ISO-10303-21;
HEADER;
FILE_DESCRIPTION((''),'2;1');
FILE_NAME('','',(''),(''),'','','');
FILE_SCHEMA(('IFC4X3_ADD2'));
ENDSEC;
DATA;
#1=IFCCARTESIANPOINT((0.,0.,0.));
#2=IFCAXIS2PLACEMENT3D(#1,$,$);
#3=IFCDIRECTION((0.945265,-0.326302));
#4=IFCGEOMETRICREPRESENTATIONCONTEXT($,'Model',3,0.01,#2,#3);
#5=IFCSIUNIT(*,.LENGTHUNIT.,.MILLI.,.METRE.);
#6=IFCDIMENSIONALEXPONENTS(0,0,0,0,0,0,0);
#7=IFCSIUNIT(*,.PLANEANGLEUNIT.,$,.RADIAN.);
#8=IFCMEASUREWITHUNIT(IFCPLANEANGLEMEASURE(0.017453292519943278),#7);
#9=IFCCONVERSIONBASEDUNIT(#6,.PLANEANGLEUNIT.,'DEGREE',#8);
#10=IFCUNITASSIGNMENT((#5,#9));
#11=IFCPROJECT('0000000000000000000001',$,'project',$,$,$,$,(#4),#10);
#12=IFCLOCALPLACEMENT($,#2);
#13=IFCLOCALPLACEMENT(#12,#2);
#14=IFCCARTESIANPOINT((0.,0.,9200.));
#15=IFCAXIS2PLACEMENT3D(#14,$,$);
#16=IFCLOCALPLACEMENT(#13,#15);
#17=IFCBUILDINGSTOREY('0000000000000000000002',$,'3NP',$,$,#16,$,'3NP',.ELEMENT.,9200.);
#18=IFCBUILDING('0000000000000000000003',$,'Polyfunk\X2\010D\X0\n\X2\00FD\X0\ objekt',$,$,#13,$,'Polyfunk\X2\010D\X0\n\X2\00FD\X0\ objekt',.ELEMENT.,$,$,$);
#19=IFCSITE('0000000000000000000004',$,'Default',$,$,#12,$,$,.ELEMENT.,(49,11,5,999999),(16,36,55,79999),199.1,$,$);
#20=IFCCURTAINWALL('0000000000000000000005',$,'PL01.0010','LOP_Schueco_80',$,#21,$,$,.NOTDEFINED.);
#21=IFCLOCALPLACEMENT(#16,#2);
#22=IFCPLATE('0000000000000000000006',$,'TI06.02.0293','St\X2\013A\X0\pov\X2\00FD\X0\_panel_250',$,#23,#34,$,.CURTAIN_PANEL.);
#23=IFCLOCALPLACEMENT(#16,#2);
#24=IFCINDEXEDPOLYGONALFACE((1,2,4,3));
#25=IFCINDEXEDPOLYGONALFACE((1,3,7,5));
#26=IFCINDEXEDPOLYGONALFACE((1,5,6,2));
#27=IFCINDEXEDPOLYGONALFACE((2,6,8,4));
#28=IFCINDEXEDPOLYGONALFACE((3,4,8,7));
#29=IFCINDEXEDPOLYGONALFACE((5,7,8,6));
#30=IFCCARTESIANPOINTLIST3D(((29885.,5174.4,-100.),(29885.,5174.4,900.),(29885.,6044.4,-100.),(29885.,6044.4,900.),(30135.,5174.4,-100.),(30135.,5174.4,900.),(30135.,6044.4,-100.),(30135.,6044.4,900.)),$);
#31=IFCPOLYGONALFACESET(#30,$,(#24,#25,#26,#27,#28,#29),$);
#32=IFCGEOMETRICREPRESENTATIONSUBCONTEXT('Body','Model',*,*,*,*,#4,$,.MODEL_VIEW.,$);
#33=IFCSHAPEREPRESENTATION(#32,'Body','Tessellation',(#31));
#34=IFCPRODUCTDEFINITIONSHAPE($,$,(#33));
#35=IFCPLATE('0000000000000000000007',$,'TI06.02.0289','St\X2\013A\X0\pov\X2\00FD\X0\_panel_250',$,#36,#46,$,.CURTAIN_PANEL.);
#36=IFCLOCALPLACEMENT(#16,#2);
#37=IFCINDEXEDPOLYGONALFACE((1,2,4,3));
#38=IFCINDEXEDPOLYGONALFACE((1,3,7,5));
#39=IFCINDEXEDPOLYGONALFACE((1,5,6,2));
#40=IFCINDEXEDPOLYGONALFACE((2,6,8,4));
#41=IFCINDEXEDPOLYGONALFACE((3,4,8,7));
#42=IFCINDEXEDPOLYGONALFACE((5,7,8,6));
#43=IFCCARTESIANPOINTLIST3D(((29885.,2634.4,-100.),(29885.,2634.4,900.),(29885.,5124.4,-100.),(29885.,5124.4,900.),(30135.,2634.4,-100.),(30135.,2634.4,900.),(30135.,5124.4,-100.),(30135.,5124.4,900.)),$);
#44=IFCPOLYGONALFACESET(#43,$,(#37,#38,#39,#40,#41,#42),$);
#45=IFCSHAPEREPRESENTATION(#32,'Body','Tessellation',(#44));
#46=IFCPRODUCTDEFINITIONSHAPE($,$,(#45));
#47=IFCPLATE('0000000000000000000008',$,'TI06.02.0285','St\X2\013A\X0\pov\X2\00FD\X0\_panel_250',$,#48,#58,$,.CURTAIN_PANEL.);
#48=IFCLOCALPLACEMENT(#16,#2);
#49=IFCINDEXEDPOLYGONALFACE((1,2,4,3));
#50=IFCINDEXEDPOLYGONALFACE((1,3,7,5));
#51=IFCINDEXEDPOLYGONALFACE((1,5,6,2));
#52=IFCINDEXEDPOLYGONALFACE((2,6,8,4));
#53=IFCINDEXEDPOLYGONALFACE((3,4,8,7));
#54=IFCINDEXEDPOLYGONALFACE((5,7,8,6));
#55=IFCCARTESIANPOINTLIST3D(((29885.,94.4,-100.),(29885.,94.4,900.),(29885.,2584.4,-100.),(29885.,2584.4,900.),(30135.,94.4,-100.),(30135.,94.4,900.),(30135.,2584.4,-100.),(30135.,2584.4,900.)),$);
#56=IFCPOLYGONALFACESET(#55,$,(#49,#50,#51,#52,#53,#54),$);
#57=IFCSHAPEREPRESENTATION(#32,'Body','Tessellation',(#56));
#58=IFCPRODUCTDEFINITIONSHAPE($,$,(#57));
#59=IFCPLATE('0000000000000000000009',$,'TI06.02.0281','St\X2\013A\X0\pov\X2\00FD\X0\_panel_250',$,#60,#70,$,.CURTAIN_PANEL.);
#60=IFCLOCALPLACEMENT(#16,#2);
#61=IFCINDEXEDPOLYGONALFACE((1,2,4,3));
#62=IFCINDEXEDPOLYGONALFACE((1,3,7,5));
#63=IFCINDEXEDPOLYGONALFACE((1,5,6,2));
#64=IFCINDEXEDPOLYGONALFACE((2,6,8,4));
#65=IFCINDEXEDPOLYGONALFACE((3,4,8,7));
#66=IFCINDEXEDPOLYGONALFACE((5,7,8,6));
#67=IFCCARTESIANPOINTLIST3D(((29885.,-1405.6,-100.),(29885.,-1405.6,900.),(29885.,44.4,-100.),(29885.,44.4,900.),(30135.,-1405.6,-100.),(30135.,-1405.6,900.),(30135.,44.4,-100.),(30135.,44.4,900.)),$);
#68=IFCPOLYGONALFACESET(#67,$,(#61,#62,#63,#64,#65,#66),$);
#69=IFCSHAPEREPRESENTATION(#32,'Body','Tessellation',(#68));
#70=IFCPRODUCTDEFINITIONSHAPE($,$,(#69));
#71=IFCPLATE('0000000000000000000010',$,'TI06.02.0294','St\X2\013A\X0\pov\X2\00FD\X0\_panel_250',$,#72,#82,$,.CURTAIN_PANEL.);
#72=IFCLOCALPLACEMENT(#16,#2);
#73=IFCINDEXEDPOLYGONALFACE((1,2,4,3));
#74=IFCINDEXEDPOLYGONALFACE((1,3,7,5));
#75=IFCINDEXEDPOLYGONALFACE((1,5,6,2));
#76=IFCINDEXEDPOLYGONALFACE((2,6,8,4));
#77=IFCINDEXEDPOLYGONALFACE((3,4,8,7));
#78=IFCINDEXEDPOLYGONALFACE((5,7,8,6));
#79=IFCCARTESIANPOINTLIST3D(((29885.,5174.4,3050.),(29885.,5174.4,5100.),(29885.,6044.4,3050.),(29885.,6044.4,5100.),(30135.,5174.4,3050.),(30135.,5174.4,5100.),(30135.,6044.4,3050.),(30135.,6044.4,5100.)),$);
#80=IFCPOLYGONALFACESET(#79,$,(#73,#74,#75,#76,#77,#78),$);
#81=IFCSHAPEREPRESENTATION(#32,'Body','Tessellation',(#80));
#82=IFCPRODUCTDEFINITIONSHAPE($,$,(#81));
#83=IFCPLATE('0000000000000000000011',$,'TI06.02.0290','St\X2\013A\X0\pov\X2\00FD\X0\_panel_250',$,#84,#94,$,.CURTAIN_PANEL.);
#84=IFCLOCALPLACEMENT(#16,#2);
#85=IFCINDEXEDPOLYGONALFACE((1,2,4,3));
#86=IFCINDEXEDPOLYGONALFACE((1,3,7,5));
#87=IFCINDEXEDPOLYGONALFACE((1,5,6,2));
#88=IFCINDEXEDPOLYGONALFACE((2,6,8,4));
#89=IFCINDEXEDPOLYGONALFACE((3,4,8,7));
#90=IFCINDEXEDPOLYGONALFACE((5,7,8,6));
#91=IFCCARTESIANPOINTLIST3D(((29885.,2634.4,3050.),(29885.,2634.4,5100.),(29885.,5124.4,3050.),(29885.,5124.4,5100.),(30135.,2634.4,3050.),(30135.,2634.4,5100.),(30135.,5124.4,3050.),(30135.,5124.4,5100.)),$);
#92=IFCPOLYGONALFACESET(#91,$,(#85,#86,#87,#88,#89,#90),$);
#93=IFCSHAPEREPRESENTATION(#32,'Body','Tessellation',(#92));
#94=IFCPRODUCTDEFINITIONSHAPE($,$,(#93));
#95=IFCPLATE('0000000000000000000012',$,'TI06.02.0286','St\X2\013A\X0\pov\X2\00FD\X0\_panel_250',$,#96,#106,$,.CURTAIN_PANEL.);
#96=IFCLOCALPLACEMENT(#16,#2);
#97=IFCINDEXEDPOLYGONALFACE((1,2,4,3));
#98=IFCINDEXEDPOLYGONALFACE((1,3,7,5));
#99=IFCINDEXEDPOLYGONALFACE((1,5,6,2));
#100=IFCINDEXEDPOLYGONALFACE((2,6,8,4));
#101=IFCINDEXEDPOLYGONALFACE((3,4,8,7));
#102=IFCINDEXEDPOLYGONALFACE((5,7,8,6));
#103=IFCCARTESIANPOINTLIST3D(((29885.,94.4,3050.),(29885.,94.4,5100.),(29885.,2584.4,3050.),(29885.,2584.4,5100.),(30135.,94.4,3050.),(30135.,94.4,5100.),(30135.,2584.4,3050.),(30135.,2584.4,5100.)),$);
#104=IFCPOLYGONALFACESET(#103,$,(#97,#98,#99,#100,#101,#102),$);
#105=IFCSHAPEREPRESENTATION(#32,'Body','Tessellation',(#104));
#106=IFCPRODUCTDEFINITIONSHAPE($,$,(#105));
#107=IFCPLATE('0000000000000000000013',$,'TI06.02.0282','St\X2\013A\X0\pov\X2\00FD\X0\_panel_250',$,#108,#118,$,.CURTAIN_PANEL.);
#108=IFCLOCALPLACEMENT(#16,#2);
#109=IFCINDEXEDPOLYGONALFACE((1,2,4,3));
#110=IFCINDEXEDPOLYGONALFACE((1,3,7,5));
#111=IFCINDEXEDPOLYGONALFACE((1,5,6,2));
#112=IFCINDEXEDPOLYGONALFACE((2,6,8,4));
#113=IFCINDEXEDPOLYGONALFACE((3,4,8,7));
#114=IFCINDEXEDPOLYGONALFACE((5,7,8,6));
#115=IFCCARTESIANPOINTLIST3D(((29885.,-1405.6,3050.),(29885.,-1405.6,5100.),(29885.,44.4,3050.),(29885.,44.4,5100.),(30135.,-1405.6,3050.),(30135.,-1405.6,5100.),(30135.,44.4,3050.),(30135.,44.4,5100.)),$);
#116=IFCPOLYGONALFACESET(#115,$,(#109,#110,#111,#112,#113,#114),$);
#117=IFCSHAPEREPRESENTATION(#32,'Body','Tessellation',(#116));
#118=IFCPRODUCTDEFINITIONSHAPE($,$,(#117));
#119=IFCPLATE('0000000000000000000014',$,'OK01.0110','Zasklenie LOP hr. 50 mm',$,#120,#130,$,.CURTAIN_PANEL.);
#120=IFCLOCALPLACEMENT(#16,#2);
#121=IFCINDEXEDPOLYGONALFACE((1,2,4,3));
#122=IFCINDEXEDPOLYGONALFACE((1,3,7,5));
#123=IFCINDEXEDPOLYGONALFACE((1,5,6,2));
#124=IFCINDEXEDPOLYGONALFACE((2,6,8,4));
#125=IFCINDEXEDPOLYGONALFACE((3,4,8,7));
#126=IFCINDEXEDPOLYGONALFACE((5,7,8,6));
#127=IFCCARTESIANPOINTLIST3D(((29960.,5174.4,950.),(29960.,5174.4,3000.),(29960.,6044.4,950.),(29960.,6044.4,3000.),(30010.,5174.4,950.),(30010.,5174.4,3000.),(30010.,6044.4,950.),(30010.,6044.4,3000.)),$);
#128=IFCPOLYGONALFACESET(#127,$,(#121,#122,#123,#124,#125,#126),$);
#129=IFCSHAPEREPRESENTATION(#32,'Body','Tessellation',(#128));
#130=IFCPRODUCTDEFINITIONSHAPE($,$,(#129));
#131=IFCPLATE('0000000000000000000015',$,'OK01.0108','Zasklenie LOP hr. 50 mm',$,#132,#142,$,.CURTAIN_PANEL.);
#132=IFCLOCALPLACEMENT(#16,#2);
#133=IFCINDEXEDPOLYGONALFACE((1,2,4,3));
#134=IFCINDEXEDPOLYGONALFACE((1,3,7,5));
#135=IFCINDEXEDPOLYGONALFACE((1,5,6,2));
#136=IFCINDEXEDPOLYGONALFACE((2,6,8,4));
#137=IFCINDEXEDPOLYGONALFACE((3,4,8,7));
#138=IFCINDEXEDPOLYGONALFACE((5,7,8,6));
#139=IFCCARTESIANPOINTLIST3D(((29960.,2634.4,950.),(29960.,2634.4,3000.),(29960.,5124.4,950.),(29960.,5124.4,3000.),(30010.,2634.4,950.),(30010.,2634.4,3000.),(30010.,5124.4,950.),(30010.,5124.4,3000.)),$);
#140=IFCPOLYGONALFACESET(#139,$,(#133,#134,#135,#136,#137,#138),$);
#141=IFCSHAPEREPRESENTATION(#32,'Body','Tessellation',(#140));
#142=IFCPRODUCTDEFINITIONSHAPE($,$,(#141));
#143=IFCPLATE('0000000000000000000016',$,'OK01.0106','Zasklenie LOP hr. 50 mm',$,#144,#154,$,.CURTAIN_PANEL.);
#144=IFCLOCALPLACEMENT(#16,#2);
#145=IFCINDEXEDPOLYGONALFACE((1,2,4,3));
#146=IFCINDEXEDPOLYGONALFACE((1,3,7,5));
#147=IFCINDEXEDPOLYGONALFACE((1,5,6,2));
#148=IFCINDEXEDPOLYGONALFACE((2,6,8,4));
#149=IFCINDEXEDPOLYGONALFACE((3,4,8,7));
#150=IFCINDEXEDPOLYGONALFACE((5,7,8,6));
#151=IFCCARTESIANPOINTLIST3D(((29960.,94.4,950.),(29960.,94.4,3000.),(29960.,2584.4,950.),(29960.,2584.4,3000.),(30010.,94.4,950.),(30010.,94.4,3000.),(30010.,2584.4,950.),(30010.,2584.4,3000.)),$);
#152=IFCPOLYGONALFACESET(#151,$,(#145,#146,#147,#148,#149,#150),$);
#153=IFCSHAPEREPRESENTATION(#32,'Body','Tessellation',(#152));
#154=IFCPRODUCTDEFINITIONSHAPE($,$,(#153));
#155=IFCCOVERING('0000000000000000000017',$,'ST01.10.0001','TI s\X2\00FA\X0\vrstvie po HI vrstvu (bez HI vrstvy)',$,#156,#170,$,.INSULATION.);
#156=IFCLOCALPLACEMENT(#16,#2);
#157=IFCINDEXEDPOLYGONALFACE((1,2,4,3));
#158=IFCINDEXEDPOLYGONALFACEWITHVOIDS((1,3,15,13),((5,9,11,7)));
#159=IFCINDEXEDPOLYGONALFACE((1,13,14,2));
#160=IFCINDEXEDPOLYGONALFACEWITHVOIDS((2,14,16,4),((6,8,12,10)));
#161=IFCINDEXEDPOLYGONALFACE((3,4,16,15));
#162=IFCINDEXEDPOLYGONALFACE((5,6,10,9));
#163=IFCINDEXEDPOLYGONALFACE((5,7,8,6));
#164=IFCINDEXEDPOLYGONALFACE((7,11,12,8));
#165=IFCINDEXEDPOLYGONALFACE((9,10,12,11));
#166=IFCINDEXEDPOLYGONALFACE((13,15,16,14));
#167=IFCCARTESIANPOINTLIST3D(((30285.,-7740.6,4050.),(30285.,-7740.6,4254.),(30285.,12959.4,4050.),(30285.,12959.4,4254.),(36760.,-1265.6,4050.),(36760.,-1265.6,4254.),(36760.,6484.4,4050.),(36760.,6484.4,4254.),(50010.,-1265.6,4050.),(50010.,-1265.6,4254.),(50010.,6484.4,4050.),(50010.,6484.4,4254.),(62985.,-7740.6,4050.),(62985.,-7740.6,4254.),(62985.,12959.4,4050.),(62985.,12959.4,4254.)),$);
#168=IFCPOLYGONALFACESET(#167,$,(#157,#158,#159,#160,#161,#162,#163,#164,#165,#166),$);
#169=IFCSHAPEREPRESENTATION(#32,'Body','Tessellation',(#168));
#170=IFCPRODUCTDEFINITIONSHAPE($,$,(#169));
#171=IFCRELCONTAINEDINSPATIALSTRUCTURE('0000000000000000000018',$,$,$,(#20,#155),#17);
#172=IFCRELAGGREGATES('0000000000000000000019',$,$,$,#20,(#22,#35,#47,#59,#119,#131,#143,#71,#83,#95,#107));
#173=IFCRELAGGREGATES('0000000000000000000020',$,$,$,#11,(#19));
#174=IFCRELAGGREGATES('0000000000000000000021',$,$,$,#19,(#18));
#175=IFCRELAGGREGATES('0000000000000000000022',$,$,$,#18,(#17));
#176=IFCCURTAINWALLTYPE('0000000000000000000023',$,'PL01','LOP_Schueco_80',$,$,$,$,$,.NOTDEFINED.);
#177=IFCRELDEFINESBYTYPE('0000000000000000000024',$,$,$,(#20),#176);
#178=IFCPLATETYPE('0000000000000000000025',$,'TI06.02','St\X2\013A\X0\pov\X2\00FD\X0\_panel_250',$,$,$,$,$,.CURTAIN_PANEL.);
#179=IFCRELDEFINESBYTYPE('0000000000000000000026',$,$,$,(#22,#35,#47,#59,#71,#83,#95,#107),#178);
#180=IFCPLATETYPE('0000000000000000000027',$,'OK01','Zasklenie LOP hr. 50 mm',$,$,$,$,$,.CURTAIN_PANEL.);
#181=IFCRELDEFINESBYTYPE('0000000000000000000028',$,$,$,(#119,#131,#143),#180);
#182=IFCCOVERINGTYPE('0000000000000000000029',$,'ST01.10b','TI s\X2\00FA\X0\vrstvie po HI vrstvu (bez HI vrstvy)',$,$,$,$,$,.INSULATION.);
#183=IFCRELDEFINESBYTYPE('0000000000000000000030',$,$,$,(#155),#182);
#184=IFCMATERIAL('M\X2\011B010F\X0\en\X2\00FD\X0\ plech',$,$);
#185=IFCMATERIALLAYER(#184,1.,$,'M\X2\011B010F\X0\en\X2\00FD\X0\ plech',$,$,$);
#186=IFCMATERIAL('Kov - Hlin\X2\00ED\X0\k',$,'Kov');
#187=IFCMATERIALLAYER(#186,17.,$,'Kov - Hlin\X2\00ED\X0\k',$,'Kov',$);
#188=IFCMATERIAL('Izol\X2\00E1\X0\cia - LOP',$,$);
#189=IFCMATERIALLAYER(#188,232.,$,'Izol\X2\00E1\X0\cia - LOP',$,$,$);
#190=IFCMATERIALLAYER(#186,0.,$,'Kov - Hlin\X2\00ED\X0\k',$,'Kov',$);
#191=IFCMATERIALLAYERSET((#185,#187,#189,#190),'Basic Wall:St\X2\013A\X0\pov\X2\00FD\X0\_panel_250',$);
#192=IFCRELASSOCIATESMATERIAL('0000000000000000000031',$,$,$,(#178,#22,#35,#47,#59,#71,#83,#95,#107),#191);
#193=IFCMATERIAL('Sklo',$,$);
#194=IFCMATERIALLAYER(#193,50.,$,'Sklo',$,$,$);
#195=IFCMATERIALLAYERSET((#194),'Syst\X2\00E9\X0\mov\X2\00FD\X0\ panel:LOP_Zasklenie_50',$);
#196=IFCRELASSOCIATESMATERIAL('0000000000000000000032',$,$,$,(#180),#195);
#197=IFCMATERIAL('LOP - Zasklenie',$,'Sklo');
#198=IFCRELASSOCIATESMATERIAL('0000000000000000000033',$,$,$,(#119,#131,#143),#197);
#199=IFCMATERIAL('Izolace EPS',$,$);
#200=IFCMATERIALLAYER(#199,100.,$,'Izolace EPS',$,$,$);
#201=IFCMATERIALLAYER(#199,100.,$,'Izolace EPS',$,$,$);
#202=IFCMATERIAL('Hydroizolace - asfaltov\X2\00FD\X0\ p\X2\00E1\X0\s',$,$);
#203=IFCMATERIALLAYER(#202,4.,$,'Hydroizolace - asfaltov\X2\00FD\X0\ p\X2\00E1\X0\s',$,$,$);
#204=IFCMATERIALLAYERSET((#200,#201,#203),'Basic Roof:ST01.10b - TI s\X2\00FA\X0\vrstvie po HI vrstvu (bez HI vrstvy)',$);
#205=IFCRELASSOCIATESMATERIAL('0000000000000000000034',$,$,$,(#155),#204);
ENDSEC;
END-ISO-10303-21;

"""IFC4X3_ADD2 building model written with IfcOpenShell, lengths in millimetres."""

from ifc_helpers import new_model, entity, si_unit, converted_unit, direction, frame, frame_2d, origin, origin_2d_with_axis, place, context, subcontext, project, spatial, rectangle, extrude, source, transform, mapped, material, layer, layer_set, layer_usage, type_object, type_shapes, element, aggregate, save


model = new_model("IFC4X3_ADD2")

# Units and contexts
model_context = context("Model", 3, precision=0.01, world=origin(), true_north=direction((0.945265, -0.326302)))
body_context = subcontext(model_context, "Body", "Model", "MODEL_VIEW")
ifc_project = project(units=[si_unit("LENGTHUNIT", "METRE", prefix="MILLI"), converted_unit("PLANEANGLEUNIT", "DEGREE", entity("IfcPlaneAngleMeasure", 0.017453292519943278), si_unit("PLANEANGLEUNIT", "RADIAN"), dimensions=[0, 0, 0, 0, 0, 0, 0])], contexts=[model_context])

# Site, building, storey
site_placement = place(None, origin())
site = spatial("IfcSite", under=ifc_project, at=site_placement, Name="Default", CompositionType="ELEMENT", RefLatitude=(49, 11, 5, 999999), RefLongitude=(16, 36, 55, 79999), RefElevation=199.1)
building_placement = place(site_placement, origin())
building = spatial("IfcBuilding", under=site, at=building_placement, Name="Polyfunkčný objekt", LongName="Polyfunkčný objekt", CompositionType="ELEMENT")
storey_placement = place(building_placement, frame((0.0, 0.0, 9200.0)))
storey = spatial("IfcBuildingStorey", under=building, at=storey_placement, Name="3NP", LongName="3NP", CompositionType="ELEMENT", Elevation=9200.0)

# Curtain wall
curtain_wall_type = type_object("IfcCurtainWallType", Name="PL01", Description="LOP_Schueco_80", PredefinedType="NOTDEFINED")
curtain_wall_1_placement = place(storey_placement, frame((0.0, 0.0, -9200.0)))
curtain_wall_1 = element("IfcCurtainWall", 1, at=curtain_wall_1_placement, inside=storey, type_object=curtain_wall_type, Name="PL01.0010", Description="LOP_Schueco_80", PredefinedType="NOTDEFINED")

# Plates
ifc_material_1 = material(Name="Měďený plech")
ifc_layer_1 = layer(ifc_material_1, 1.0, Name="Měďený plech")
ifc_material_2 = material(Name="Kov - Hliník", Category="Kov")
ifc_layer_2 = layer(ifc_material_2, 17.0, Name="Kov - Hliník", Category="Kov")
ifc_material_3 = material(Name="Izolácia - LOP")
ifc_layer_3 = layer(ifc_material_3, 232.0, Name="Izolácia - LOP")
ifc_layer_4 = layer(ifc_material_2, 0.0, Name="Kov - Hliník", Category="Kov")
ifc_layer_set_1 = layer_set([ifc_layer_1, ifc_layer_2, ifc_layer_3, ifc_layer_4], Name="Basic Wall:Stĺpový_panel_250")
ifc_layer_usage_1 = layer_usage(ifc_layer_set_1, "AXIS2", "POSITIVE", -125.0)
plate_type_1 = type_object("IfcPlateType", Name="TI06.02", Description="Stĺpový_panel_250", PredefinedType="CURTAIN_PANEL", material=ifc_layer_set_1)
plate_1_placement = place(storey_placement, frame((30010.0, 6044.4, -100.0), z_axis=(0.0, 0.0, 1.0), x_axis=(0.0, -1.0, 0.0)))
plate_1 = element("IfcPlate", 2, at=plate_1_placement, type_object=plate_type_1, material=ifc_layer_usage_1, Name="TI06.02.0293", Description="Stĺpový_panel_250", PredefinedType="CURTAIN_PANEL", context=body_context, shape_type="SweptSolid", body=[
    extrude(rectangle(XDim=250.0, YDim=870.0, at=frame_2d((0.0, 0.0), x_axis=(1.0, 0.0))), frame((435.0, 0.0, 0.0), z_axis=(0.0, 0.0, 1.0), x_axis=(0.0, 1.0, 0.0)), (0.0, 0.0, 1.0), 1000.0),
])
ifc_layer_usage_2 = layer_usage(ifc_layer_set_1, "AXIS2", "POSITIVE", -125.0)
plate_2_placement = place(storey_placement, frame((30010.0, 5124.4, -100.0), z_axis=(0.0, 0.0, 1.0), x_axis=(0.0, -1.0, 0.0)))
plate_2 = element("IfcPlate", 3, at=plate_2_placement, type_object=plate_type_1, material=ifc_layer_usage_2, Name="TI06.02.0289", Description="Stĺpový_panel_250", PredefinedType="CURTAIN_PANEL", context=body_context, shape_type="SweptSolid", body=[
    extrude(rectangle(XDim=250.0, YDim=2490.0, at=frame_2d((0.0, 0.0), x_axis=(1.0, 0.0))), frame((1245.0, 0.0, 0.0), z_axis=(0.0, 0.0, 1.0), x_axis=(0.0, 1.0, 0.0)), (0.0, 0.0, 1.0), 1000.0),
])
ifc_layer_usage_3 = layer_usage(ifc_layer_set_1, "AXIS2", "POSITIVE", -125.0)
plate_3_placement = place(storey_placement, frame((30010.0, 2584.4, -100.0), z_axis=(0.0, 0.0, 1.0), x_axis=(0.0, -1.0, 0.0)))
plate_3 = element("IfcPlate", 4, at=plate_3_placement, type_object=plate_type_1, material=ifc_layer_usage_3, Name="TI06.02.0285", Description="Stĺpový_panel_250", PredefinedType="CURTAIN_PANEL", context=body_context, shape_type="SweptSolid", body=[
    extrude(rectangle(XDim=250.0, YDim=2490.0, at=frame_2d((0.0, 0.0), x_axis=(1.0, 0.0))), frame((1245.0, 0.0, 0.0), z_axis=(0.0, 0.0, 1.0), x_axis=(0.0, 1.0, 0.0)), (0.0, 0.0, 1.0), 1000.0),
])
ifc_layer_usage_4 = layer_usage(ifc_layer_set_1, "AXIS2", "POSITIVE", -125.0)
plate_4_placement = place(storey_placement, frame((30010.0, 44.4, -100.0), z_axis=(0.0, 0.0, 1.0), x_axis=(0.0, -1.0, 0.0)))
plate_4 = element("IfcPlate", 5, at=plate_4_placement, type_object=plate_type_1, material=ifc_layer_usage_4, Name="TI06.02.0281", Description="Stĺpový_panel_250", PredefinedType="CURTAIN_PANEL", context=body_context, shape_type="SweptSolid", body=[
    extrude(rectangle(XDim=250.0, YDim=1450.0, at=frame_2d((0.0, 0.0), x_axis=(1.0, 0.0))), frame((725.0, 0.0, 0.0), z_axis=(0.0, 0.0, 1.0), x_axis=(0.0, 1.0, 0.0)), (0.0, 0.0, 1.0), 1000.0),
])
ifc_layer_usage_5 = layer_usage(ifc_layer_set_1, "AXIS2", "POSITIVE", -125.0)
plate_5_placement = place(storey_placement, frame((30010.0, 6044.4, 3050.0), z_axis=(0.0, 0.0, 1.0), x_axis=(0.0, -1.0, 0.0)))
plate_5 = element("IfcPlate", 6, at=plate_5_placement, type_object=plate_type_1, material=ifc_layer_usage_5, Name="TI06.02.0294", Description="Stĺpový_panel_250", PredefinedType="CURTAIN_PANEL", context=body_context, shape_type="SweptSolid", body=[
    extrude(rectangle(XDim=250.0, YDim=870.0, at=frame_2d((0.0, 0.0), x_axis=(1.0, 0.0))), frame((435.0, 0.0, 0.0), z_axis=(0.0, 0.0, 1.0), x_axis=(0.0, 1.0, 0.0)), (0.0, 0.0, 1.0), 2050.0),
])
ifc_layer_usage_6 = layer_usage(ifc_layer_set_1, "AXIS2", "POSITIVE", -125.0)
plate_6_placement = place(storey_placement, frame((30010.0, 5124.4, 3050.0), z_axis=(0.0, 0.0, 1.0), x_axis=(0.0, -1.0, 0.0)))
plate_6 = element("IfcPlate", 7, at=plate_6_placement, type_object=plate_type_1, material=ifc_layer_usage_6, Name="TI06.02.0290", Description="Stĺpový_panel_250", PredefinedType="CURTAIN_PANEL", context=body_context, shape_type="SweptSolid", body=[
    extrude(rectangle(XDim=250.0, YDim=2490.0, at=frame_2d((0.0, 0.0), x_axis=(1.0, 0.0))), frame((1245.0, 0.0, 0.0), z_axis=(0.0, 0.0, 1.0), x_axis=(0.0, 1.0, 0.0)), (0.0, 0.0, 1.0), 2050.0),
])
ifc_layer_usage_7 = layer_usage(ifc_layer_set_1, "AXIS2", "POSITIVE", -125.0)
plate_7_placement = place(storey_placement, frame((30010.0, 2584.4, 3050.0), z_axis=(0.0, 0.0, 1.0), x_axis=(0.0, -1.0, 0.0)))
plate_7 = element("IfcPlate", 8, at=plate_7_placement, type_object=plate_type_1, material=ifc_layer_usage_7, Name="TI06.02.0286", Description="Stĺpový_panel_250", PredefinedType="CURTAIN_PANEL", context=body_context, shape_type="SweptSolid", body=[
    extrude(rectangle(XDim=250.0, YDim=2490.0, at=frame_2d((0.0, 0.0), x_axis=(1.0, 0.0))), frame((1245.0, 0.0, 0.0), z_axis=(0.0, 0.0, 1.0), x_axis=(0.0, 1.0, 0.0)), (0.0, 0.0, 1.0), 2050.0),
])
ifc_layer_usage_8 = layer_usage(ifc_layer_set_1, "AXIS2", "POSITIVE", -125.0)
plate_8_placement = place(storey_placement, frame((30010.0, 44.4, 3050.0), z_axis=(0.0, 0.0, 1.0), x_axis=(0.0, -1.0, 0.0)))
plate_8 = element("IfcPlate", 9, at=plate_8_placement, type_object=plate_type_1, material=ifc_layer_usage_8, Name="TI06.02.0282", Description="Stĺpový_panel_250", PredefinedType="CURTAIN_PANEL", context=body_context, shape_type="SweptSolid", body=[
    extrude(rectangle(XDim=250.0, YDim=1450.0, at=frame_2d((0.0, 0.0), x_axis=(1.0, 0.0))), frame((725.0, 0.0, 0.0), z_axis=(0.0, 0.0, 1.0), x_axis=(0.0, 1.0, 0.0)), (0.0, 0.0, 1.0), 2050.0),
])
ifc_material_4 = material(Name="LOP - Zasklenie", Category="Sklo")
ifc_material_5 = material(Name="Sklo")
ifc_layer_5 = layer(ifc_material_5, 50.0, Name="Sklo")
ifc_layer_set_2 = layer_set([ifc_layer_5], Name="Systémový panel:LOP_Zasklenie_50")
plate_type_2 = type_object("IfcPlateType", Name="OK01", Description="Zasklenie LOP hr. 50 mm", PredefinedType="CURTAIN_PANEL", material=ifc_layer_set_2)
shared_shape_1 = source(origin(), body_context, "Body", "SweptSolid", [
    extrude(rectangle(XDim=50.0, YDim=870.0, at=origin_2d_with_axis()), frame((0.0, -25.0, 0.0), z_axis=(0.0, 0.0, 1.0), x_axis=(0.0, 1.0, 0.0)), (0.0, 0.0, 1.0), 2050.0),
])
plate_9_placement = place(curtain_wall_1_placement, frame((30010.0, 5609.4, 10150.0), z_axis=(0.0, 0.0, 1.0), x_axis=(0.0, -1.0, 0.0)))
plate_9 = element("IfcPlate", 10, at=plate_9_placement, type_object=plate_type_2, material=ifc_material_4, Name="OK01.0110", Description="Zasklenie LOP hr. 50 mm", PredefinedType="CURTAIN_PANEL", context=body_context, shape_type="MappedRepresentation", body=[
    mapped(shared_shape_1, transform((0.0, 0.0, 0.0), scale=1.0)),
])
shared_shape_2 = source(origin(), body_context, "Body", "SweptSolid", [
    extrude(rectangle(XDim=50.0, YDim=2490.0, at=origin_2d_with_axis()), frame((0.0, -25.0, 0.0), z_axis=(0.0, 0.0, 1.0), x_axis=(0.0, 1.0, 0.0)), (0.0, 0.0, 1.0), 2050.0),
])
type_shapes(plate_type_2, [shared_shape_1, shared_shape_2])
plate_10_placement = place(curtain_wall_1_placement, frame((30010.0, 3879.4, 10150.0), z_axis=(0.0, 0.0, 1.0), x_axis=(0.0, -1.0, 0.0)))
plate_10 = element("IfcPlate", 11, at=plate_10_placement, type_object=plate_type_2, material=ifc_material_4, Name="OK01.0108", Description="Zasklenie LOP hr. 50 mm", PredefinedType="CURTAIN_PANEL", context=body_context, shape_type="MappedRepresentation", body=[
    mapped(shared_shape_2, transform((0.0, 0.0, 0.0), scale=1.0)),
])
plate_11_placement = place(curtain_wall_1_placement, frame((30010.0, 1339.4, 10150.0), z_axis=(0.0, 0.0, 1.0), x_axis=(0.0, -1.0, 0.0)))
plate_11 = element("IfcPlate", 12, at=plate_11_placement, type_object=plate_type_2, material=ifc_material_4, Name="OK01.0106", Description="Zasklenie LOP hr. 50 mm", PredefinedType="CURTAIN_PANEL", context=body_context, shape_type="MappedRepresentation", body=[
    mapped(shared_shape_2, transform((0.0, 0.0, 0.0), scale=1.0)),
])
aggregate(curtain_wall_1, [plate_1, plate_2, plate_3, plate_4, plate_9, plate_10, plate_11, plate_5, plate_6, plate_7, plate_8])

# Covering, opening
ifc_material_6 = material(Name="Izolace EPS")
ifc_layer_6 = layer(ifc_material_6, 100.0, Name="Izolace EPS")
ifc_layer_7 = layer(ifc_material_6, 100.0, Name="Izolace EPS")
ifc_material_7 = material(Name="Hydroizolace - asfaltový pás")
ifc_layer_8 = layer(ifc_material_7, 4.0, Name="Hydroizolace - asfaltový pás")
ifc_layer_set_3 = layer_set([ifc_layer_6, ifc_layer_7, ifc_layer_8], Name="Basic Roof:ST01.10b - TI súvrstvie po HI vrstvu (bez HI vrstvy)")
covering_type_1 = type_object("IfcCoveringType", Name="ST01.10b", Description="TI súvrstvie po HI vrstvu (bez HI vrstvy)", PredefinedType="INSULATION")
covering_1_placement = place(storey_placement, frame((30285.0, -7740.6, 4050.0)))
covering_1 = element("IfcCovering", 13, at=covering_1_placement, inside=storey, type_object=covering_type_1, material=ifc_layer_set_3, Name="ST01.10.0001", Description="TI súvrstvie po HI vrstvu (bez HI vrstvy)", PredefinedType="INSULATION", context=body_context, shape_type="SweptSolid", body=[
    extrude(rectangle(XDim=20700.0, YDim=32700.0, at=frame_2d((0.0, 0.0), x_axis=(1.0, 0.0))), frame((16350.0, 10350.0, 0.0), z_axis=(0.0, 0.0, 1.0), x_axis=(0.0, -1.0, 0.0)), (0.0, 0.0, 1.0), 204.0),
])
opening_placement = place(storey_placement, frame((30285.0, -7740.6, 4050.0)))
element("IfcOpeningElement", 14, at=opening_placement, cuts=covering_1, PredefinedType="OPENING", context=body_context, shape_type="SweptSolid", body=[
    extrude(rectangle(XDim=7750.0, YDim=13250.0, at=frame_2d((-31.2, 31.2), x_axis=(1.0, 0.0))), frame((13131.3, 10381.2, 0.0), z_axis=(0.0, 0.0, 1.0), x_axis=(0.0, 1.0, 0.0)), (0.0, 0.0, 1.0), 204.0),
])

save(model, "model.ifc")
